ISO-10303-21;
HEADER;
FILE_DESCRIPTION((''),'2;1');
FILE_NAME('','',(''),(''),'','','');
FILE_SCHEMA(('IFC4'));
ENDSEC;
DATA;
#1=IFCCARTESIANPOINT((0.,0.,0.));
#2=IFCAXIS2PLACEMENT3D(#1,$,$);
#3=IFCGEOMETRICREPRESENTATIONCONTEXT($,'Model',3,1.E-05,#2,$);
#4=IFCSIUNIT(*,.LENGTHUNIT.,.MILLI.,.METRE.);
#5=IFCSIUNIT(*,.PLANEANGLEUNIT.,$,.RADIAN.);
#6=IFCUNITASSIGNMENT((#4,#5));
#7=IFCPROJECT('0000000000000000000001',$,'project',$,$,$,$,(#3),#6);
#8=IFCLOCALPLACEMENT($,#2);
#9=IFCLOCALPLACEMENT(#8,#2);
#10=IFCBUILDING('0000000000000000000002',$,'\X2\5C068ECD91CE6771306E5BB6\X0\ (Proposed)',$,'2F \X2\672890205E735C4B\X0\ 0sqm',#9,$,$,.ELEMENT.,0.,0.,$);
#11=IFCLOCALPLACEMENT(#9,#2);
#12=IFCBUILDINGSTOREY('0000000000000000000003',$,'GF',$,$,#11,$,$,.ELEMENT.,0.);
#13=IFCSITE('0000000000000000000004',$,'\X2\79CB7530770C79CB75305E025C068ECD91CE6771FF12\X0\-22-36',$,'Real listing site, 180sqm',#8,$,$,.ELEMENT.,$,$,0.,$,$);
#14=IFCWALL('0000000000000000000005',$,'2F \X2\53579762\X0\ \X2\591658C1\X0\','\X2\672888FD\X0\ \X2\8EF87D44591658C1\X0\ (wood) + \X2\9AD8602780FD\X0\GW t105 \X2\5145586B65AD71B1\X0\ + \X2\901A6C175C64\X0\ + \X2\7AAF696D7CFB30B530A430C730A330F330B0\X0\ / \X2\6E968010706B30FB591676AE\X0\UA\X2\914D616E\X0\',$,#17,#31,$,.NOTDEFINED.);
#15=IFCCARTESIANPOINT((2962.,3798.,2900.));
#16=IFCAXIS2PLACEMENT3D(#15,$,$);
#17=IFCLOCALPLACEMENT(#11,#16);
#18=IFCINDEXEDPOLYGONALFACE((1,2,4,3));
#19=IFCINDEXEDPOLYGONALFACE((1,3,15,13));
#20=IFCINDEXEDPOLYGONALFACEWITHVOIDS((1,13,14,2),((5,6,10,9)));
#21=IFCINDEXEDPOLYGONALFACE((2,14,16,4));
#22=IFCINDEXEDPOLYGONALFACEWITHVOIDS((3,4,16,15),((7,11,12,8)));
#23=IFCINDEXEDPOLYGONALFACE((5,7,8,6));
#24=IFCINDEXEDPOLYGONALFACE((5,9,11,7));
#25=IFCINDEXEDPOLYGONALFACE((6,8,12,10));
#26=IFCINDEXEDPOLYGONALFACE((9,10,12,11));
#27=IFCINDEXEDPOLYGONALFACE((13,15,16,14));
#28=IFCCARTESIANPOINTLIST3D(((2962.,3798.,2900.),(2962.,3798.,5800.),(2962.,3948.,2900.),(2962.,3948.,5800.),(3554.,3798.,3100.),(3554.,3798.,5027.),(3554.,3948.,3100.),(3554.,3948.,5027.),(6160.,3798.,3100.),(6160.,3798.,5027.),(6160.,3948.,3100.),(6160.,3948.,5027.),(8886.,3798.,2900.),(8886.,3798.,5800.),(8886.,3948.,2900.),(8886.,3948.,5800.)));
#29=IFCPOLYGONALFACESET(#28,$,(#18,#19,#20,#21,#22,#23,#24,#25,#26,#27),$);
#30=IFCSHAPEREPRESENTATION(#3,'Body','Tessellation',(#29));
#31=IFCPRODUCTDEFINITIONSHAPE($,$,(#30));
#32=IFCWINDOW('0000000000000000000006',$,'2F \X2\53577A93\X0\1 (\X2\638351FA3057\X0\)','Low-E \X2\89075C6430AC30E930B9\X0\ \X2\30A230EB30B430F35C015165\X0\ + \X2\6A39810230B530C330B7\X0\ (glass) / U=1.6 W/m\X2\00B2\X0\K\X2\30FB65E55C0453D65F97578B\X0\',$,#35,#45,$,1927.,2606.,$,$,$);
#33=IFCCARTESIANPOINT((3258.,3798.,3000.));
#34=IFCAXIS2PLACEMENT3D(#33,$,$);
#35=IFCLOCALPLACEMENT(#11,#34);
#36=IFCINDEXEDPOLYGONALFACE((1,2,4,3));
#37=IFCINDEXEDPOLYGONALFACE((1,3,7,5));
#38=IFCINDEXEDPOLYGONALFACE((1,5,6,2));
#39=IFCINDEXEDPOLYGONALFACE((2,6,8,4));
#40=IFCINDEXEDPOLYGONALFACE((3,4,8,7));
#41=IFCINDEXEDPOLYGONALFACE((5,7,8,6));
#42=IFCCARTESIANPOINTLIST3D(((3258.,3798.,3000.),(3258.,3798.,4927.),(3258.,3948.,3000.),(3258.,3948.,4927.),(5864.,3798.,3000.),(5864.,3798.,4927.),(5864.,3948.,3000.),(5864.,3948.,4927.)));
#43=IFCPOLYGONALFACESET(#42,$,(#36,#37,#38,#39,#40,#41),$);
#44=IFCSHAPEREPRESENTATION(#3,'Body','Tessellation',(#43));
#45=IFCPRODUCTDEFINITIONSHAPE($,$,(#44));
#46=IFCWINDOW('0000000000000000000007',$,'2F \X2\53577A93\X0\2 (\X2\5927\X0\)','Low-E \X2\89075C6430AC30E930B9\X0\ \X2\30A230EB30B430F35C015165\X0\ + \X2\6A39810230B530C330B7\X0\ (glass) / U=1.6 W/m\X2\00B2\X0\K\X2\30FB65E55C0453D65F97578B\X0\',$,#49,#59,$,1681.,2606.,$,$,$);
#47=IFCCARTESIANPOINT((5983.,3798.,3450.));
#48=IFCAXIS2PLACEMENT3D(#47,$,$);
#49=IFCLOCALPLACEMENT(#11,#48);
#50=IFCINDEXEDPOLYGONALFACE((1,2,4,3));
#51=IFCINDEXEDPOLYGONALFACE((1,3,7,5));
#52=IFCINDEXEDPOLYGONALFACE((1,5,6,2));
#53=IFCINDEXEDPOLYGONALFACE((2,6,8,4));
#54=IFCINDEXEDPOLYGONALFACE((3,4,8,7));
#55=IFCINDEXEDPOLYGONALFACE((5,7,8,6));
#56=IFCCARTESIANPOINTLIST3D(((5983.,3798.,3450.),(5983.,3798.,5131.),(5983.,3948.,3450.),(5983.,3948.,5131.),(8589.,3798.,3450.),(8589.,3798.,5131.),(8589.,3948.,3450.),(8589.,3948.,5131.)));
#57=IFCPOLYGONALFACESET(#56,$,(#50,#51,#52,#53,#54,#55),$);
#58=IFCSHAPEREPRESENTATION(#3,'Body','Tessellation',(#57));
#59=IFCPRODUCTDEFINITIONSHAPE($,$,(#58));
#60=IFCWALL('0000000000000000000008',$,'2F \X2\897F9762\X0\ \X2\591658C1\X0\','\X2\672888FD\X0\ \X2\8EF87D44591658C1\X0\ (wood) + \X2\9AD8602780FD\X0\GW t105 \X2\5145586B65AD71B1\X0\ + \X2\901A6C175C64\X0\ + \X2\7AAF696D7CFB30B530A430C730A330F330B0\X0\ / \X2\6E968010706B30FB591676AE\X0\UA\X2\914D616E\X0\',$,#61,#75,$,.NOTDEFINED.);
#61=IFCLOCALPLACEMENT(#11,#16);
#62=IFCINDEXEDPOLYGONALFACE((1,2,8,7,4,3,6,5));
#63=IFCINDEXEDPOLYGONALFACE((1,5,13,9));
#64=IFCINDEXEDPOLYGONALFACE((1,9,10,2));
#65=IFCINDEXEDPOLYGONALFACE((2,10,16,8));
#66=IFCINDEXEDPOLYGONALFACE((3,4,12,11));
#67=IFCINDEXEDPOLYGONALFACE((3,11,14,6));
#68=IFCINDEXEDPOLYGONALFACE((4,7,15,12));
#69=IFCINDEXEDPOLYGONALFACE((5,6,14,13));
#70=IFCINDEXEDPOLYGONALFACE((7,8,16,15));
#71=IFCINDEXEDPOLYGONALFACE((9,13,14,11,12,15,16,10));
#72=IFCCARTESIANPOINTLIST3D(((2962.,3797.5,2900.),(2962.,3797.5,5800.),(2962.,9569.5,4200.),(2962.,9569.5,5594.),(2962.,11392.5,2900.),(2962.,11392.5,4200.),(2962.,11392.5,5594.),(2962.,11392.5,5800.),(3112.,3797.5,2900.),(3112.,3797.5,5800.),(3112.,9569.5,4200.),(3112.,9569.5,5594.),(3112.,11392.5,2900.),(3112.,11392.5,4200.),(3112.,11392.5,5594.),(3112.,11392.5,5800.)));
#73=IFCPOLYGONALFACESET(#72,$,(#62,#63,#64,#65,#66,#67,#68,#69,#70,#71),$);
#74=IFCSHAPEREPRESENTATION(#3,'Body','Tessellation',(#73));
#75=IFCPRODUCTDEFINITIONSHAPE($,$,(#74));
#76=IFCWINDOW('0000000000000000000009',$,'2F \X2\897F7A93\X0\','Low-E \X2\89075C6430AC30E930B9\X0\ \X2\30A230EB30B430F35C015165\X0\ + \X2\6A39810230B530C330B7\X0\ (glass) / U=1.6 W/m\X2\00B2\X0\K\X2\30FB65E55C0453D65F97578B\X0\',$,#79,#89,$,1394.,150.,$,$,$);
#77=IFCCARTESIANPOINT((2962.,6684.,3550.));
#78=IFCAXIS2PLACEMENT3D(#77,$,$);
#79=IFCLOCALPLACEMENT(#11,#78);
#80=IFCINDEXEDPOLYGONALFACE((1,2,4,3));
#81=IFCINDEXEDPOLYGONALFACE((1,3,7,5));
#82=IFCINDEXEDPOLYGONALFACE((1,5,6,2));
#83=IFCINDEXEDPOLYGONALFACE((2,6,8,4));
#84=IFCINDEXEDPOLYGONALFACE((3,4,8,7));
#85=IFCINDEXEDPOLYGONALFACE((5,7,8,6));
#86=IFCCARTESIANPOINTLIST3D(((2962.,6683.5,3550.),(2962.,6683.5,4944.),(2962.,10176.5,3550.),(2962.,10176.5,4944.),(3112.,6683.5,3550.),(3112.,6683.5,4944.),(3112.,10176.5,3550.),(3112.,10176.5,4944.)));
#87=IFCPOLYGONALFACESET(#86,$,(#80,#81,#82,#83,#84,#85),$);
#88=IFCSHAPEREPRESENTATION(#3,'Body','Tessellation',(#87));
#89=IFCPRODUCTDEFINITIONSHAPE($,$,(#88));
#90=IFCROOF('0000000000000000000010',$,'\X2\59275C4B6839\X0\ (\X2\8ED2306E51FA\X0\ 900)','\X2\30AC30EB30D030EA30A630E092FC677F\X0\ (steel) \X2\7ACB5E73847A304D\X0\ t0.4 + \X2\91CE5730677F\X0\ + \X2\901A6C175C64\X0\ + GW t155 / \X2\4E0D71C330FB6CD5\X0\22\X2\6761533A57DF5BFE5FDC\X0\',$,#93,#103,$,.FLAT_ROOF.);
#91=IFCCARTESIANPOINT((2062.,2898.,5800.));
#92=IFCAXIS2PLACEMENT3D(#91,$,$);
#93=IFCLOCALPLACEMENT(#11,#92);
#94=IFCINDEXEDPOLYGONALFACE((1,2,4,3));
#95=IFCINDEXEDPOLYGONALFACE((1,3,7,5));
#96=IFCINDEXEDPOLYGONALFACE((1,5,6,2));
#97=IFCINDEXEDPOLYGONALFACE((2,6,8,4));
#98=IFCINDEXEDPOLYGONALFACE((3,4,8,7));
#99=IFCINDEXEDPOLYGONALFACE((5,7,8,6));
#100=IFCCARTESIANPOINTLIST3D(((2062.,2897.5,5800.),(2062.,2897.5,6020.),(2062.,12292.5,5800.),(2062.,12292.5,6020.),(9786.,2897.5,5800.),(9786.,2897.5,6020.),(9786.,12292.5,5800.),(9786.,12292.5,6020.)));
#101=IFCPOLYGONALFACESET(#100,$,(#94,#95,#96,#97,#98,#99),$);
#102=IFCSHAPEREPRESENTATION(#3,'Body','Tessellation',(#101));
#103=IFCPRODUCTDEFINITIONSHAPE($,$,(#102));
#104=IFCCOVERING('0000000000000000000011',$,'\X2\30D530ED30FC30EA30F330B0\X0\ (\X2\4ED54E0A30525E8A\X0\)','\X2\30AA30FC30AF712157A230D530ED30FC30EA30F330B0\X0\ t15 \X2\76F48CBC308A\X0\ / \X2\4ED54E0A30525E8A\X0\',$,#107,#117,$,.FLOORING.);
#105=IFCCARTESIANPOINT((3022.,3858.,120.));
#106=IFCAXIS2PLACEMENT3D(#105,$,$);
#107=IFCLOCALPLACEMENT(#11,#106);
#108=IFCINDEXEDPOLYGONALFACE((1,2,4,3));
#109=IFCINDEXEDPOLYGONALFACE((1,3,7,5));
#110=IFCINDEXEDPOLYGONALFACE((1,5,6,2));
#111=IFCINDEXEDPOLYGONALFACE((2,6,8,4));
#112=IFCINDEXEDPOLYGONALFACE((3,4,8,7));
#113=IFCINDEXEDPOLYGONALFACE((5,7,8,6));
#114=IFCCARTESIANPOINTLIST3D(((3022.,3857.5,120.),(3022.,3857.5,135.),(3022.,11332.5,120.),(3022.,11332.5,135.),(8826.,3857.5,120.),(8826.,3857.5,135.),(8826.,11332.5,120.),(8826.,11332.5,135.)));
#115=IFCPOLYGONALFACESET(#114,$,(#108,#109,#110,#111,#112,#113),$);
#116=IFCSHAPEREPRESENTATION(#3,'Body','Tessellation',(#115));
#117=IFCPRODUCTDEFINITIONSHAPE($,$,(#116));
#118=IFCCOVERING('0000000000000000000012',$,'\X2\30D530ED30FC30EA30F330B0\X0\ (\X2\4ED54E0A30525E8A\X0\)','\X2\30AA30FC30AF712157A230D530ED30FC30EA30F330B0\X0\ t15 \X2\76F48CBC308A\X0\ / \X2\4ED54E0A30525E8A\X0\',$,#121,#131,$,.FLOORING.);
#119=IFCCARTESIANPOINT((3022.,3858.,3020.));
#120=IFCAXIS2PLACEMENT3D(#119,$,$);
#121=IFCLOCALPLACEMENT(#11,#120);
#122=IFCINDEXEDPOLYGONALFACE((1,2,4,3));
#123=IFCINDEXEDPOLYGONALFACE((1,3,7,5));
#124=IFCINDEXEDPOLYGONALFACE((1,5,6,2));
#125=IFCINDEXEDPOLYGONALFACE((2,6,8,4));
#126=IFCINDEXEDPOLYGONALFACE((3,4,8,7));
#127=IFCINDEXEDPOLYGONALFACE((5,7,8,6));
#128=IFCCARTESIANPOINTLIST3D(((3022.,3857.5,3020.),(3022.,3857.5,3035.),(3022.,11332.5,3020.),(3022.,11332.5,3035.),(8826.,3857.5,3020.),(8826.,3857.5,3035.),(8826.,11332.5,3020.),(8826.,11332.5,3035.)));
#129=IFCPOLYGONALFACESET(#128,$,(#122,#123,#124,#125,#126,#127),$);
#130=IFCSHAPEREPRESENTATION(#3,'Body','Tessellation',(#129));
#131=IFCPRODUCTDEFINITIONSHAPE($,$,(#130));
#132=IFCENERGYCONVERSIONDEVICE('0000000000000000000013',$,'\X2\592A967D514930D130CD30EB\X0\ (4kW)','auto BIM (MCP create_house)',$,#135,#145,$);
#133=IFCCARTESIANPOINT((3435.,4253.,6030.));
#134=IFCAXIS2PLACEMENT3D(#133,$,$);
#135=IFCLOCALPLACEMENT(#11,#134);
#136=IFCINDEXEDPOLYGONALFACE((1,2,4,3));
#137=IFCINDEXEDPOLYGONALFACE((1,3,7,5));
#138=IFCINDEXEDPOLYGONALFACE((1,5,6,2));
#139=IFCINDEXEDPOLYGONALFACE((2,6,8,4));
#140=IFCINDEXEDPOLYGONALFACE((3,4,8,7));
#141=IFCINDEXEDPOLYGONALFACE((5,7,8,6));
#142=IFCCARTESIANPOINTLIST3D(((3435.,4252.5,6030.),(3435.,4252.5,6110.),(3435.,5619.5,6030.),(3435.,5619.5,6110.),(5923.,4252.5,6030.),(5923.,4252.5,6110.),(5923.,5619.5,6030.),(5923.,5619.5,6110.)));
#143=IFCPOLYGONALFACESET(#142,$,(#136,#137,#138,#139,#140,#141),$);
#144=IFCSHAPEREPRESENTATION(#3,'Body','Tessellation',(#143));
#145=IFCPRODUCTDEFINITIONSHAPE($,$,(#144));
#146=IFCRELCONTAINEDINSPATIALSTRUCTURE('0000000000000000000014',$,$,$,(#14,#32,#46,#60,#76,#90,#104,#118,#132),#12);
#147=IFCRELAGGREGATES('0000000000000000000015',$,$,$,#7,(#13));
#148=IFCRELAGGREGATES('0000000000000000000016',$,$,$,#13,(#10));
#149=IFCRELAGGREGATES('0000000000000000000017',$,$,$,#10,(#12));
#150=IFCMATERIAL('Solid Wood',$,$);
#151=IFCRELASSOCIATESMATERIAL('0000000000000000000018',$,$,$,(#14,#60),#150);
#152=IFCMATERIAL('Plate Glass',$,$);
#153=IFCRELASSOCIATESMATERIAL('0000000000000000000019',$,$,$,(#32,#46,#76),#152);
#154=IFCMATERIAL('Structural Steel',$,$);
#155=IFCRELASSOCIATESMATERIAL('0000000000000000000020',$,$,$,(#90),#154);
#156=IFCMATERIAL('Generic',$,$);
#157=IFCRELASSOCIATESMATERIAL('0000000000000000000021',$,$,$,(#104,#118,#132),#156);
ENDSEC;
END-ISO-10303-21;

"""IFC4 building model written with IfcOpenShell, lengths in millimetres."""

from ifc_helpers import new_model, si_unit, frame, frame_2d, origin, place, context, project, spatial, rectangle, extrude, material, element, fill, save


model = new_model("IFC4")

# Units and contexts
model_context = context("Model", 3, precision=1e-05, world=origin())
ifc_project = project(units=[si_unit("LENGTHUNIT", "METRE", prefix="MILLI"), si_unit("PLANEANGLEUNIT", "RADIAN")], contexts=[model_context])

# Site, building, storey
site_placement = place(None, origin())
site = spatial("IfcSite", under=ifc_project, at=site_placement, Name="秋田県秋田市将軍野東２-22-36", ObjectType="Real listing site, 180sqm", CompositionType="ELEMENT", RefElevation=0.0)
building_placement = place(site_placement, origin())
building = spatial("IfcBuilding", under=site, at=building_placement, Name="将軍野東の家 (Proposed)", ObjectType="2F 木造平屋 0sqm", CompositionType="ELEMENT", ElevationOfRefHeight=0.0, ElevationOfTerrain=0.0)
storey_placement = place(building_placement, origin())
storey = spatial("IfcBuildingStorey", under=building, at=storey_placement, Name="GF", CompositionType="ELEMENT", Elevation=0.0)

# Shared definitions
ifc_material_1 = material(Name="Solid Wood")

# Shared definitions
ifc_material_2 = material(Name="Plate Glass")

# Wall, openings, windows
wall_1_placement = place(storey_placement, frame((2962.0, 3798.0, 2900.0)))
wall_1 = element("IfcWall", 1, at=wall_1_placement, inside=storey, material=ifc_material_1, Name="2F 南面 外壁", Description="木製 軸組外壁 (wood) + 高性能GW t105 充填断熱 + 通気層 + 窯業系サイディング / 準耐火・外皮UA配慮", PredefinedType="NOTDEFINED", context=model_context, shape_type="SweptSolid", body=[
    extrude(rectangle(XDim=5924.0, YDim=150.0, at=frame_2d((2962.0, 75.0))), frame((2962.0, 3798.0, 2900.0)), (0.0, 0.0, 1.0), 2900.0),
])
opening_1_placement = place(storey_placement, frame((3258.0, 3798.0, 3000.0)))
opening_1 = element("IfcOpeningElement", 2, at=opening_1_placement, cuts=wall_1, PredefinedType="NOTDEFINED", context=model_context, shape_type="SweptSolid", body=[
    extrude(rectangle(XDim=2606.0, YDim=150.0, at=frame_2d((1303.0, 75.0))), frame((3258.0, 3798.0, 3000.0)), (0.0, 0.0, 1.0), 1927.0),
])
opening_2_placement = place(storey_placement, frame((5983.0, 3798.0, 3450.0)))
opening_2 = element("IfcOpeningElement", 3, at=opening_2_placement, cuts=wall_1, PredefinedType="NOTDEFINED", context=model_context, shape_type="SweptSolid", body=[
    extrude(rectangle(XDim=2606.0, YDim=150.0, at=frame_2d((1303.0, 75.0))), frame((5983.0, 3798.0, 3450.0)), (0.0, 0.0, 1.0), 1681.0),
])
window_1_placement = place(storey_placement, frame((3258.0, 3798.0, 3000.0)))
window_1 = element("IfcWindow", 4, at=window_1_placement, inside=storey, material=ifc_material_2, Name="2F 南窓1 (掃出し)", Description="Low-E 複層ガラス アルゴン封入 + 樹脂サッシ (glass) / U=1.6 W/m²K・日射取得型", OverallHeight=1927.0, OverallWidth=2606.0, context=model_context, shape_type="SweptSolid", body=[
    extrude(rectangle(XDim=2606.0, YDim=150.0, at=frame_2d((1303.0, 75.0))), frame((3258.0, 3798.0, 3000.0)), (0.0, 0.0, 1.0), 1927.0),
])
fill(opening_1, window_1)
window_2_placement = place(storey_placement, frame((5983.0, 3798.0, 3450.0)))
window_2 = element("IfcWindow", 5, at=window_2_placement, inside=storey, material=ifc_material_2, Name="2F 南窓2 (大)", Description="Low-E 複層ガラス アルゴン封入 + 樹脂サッシ (glass) / U=1.6 W/m²K・日射取得型", OverallHeight=1681.0, OverallWidth=2606.0, context=model_context, shape_type="SweptSolid", body=[
    extrude(rectangle(XDim=2606.0, YDim=150.0, at=frame_2d((1303.0, 75.0))), frame((5983.0, 3798.0, 3450.0)), (0.0, 0.0, 1.0), 1681.0),
])
fill(opening_2, window_2)

# Wall, opening, window
wall_2_placement = place(storey_placement, frame((2962.0, 3798.0, 2900.0)))
wall_2 = element("IfcWall", 6, at=wall_2_placement, inside=storey, material=ifc_material_1, Name="2F 西面 外壁", Description="木製 軸組外壁 (wood) + 高性能GW t105 充填断熱 + 通気層 + 窯業系サイディング / 準耐火・外皮UA配慮", PredefinedType="NOTDEFINED", context=model_context, shape_type="SweptSolid", body=[
    extrude(rectangle(XDim=150.0, YDim=7595.0, at=frame_2d((75.0, 3797.0))), frame((2962.0, 3798.0, 2900.0)), (0.0, 0.0, 1.0), 2900.0),
])
opening_3_placement = place(storey_placement, frame((2962.0, 6684.0, 3550.0)))
opening_3 = element("IfcOpeningElement", 7, at=opening_3_placement, cuts=wall_2, PredefinedType="NOTDEFINED", context=model_context, shape_type="SweptSolid", body=[
    extrude(rectangle(XDim=150.0, YDim=3493.0, at=frame_2d((75.0, 1746.0))), frame((2962.0, 6684.0, 3550.0)), (0.0, 0.0, 1.0), 1394.0),
])
window_3_placement = place(storey_placement, frame((2962.0, 6684.0, 3550.0)))
window_3 = element("IfcWindow", 8, at=window_3_placement, inside=storey, material=ifc_material_2, Name="2F 西窓", Description="Low-E 複層ガラス アルゴン封入 + 樹脂サッシ (glass) / U=1.6 W/m²K・日射取得型", OverallHeight=1394.0, OverallWidth=150.0, context=model_context, shape_type="SweptSolid", body=[
    extrude(rectangle(XDim=150.0, YDim=3493.0, at=frame_2d((75.0, 1746.0))), frame((2962.0, 6684.0, 3550.0)), (0.0, 0.0, 1.0), 1394.0),
])
fill(opening_3, window_3)

# Roof
ifc_material_3 = material(Name="Structural Steel")
roof_placement = place(storey_placement, frame((2062.0, 2898.0, 5800.0)))
element("IfcRoof", 9, at=roof_placement, inside=storey, material=ifc_material_3, Name="大屋根 (軒の出 900)", Description="ガルバリウム鋼板 (steel) 立平葺き t0.4 + 野地板 + 通気層 + GW t155 / 不燃・法22条区域対応", PredefinedType="FLAT_ROOF", context=model_context, shape_type="SweptSolid", body=[
    extrude(rectangle(XDim=7724.0, YDim=9395.0, at=frame_2d((3862.0, 4697.0))), frame((2062.0, 2898.0, 5800.0)), (0.0, 0.0, 1.0), 220.0),
])

# Coverings
ifc_material_4 = material(Name="Generic")
covering_1_placement = place(storey_placement, frame((3022.0, 3858.0, 120.0)))
element("IfcCovering", 10, at=covering_1_placement, inside=storey, material=ifc_material_4, Name="フローリング (仕上げ床)", Description="オーク無垢フローリング t15 直貼り / 仕上げ床", PredefinedType="FLOORING", context=model_context, shape_type="SweptSolid", body=[
    extrude(rectangle(XDim=5804.0, YDim=7475.0, at=frame_2d((2902.0, 3737.0))), frame((3022.0, 3858.0, 120.0)), (0.0, 0.0, 1.0), 15.0),
])
covering_2_placement = place(storey_placement, frame((3022.0, 3858.0, 3020.0)))
element("IfcCovering", 11, at=covering_2_placement, inside=storey, material=ifc_material_4, Name="フローリング (仕上げ床)", Description="オーク無垢フローリング t15 直貼り / 仕上げ床", PredefinedType="FLOORING", context=model_context, shape_type="SweptSolid", body=[
    extrude(rectangle(XDim=5804.0, YDim=7475.0, at=frame_2d((2902.0, 3737.0))), frame((3022.0, 3858.0, 3020.0)), (0.0, 0.0, 1.0), 15.0),
])

# Energy conversion device
energy_conversion_device_placement = place(storey_placement, frame((3435.0, 4253.0, 6030.0)))
element("IfcEnergyConversionDevice", 12, at=energy_conversion_device_placement, inside=storey, material=ifc_material_4, Name="太陽光パネル (4kW)", Description="auto BIM (MCP create_house)", context=model_context, shape_type="SweptSolid", body=[
    extrude(rectangle(XDim=2488.0, YDim=1367.0, at=frame_2d((1244.0, 683.0))), frame((3435.0, 4253.0, 6030.0)), (0.0, 0.0, 1.0), 80.0),
])

save(model, "model.ifc")
